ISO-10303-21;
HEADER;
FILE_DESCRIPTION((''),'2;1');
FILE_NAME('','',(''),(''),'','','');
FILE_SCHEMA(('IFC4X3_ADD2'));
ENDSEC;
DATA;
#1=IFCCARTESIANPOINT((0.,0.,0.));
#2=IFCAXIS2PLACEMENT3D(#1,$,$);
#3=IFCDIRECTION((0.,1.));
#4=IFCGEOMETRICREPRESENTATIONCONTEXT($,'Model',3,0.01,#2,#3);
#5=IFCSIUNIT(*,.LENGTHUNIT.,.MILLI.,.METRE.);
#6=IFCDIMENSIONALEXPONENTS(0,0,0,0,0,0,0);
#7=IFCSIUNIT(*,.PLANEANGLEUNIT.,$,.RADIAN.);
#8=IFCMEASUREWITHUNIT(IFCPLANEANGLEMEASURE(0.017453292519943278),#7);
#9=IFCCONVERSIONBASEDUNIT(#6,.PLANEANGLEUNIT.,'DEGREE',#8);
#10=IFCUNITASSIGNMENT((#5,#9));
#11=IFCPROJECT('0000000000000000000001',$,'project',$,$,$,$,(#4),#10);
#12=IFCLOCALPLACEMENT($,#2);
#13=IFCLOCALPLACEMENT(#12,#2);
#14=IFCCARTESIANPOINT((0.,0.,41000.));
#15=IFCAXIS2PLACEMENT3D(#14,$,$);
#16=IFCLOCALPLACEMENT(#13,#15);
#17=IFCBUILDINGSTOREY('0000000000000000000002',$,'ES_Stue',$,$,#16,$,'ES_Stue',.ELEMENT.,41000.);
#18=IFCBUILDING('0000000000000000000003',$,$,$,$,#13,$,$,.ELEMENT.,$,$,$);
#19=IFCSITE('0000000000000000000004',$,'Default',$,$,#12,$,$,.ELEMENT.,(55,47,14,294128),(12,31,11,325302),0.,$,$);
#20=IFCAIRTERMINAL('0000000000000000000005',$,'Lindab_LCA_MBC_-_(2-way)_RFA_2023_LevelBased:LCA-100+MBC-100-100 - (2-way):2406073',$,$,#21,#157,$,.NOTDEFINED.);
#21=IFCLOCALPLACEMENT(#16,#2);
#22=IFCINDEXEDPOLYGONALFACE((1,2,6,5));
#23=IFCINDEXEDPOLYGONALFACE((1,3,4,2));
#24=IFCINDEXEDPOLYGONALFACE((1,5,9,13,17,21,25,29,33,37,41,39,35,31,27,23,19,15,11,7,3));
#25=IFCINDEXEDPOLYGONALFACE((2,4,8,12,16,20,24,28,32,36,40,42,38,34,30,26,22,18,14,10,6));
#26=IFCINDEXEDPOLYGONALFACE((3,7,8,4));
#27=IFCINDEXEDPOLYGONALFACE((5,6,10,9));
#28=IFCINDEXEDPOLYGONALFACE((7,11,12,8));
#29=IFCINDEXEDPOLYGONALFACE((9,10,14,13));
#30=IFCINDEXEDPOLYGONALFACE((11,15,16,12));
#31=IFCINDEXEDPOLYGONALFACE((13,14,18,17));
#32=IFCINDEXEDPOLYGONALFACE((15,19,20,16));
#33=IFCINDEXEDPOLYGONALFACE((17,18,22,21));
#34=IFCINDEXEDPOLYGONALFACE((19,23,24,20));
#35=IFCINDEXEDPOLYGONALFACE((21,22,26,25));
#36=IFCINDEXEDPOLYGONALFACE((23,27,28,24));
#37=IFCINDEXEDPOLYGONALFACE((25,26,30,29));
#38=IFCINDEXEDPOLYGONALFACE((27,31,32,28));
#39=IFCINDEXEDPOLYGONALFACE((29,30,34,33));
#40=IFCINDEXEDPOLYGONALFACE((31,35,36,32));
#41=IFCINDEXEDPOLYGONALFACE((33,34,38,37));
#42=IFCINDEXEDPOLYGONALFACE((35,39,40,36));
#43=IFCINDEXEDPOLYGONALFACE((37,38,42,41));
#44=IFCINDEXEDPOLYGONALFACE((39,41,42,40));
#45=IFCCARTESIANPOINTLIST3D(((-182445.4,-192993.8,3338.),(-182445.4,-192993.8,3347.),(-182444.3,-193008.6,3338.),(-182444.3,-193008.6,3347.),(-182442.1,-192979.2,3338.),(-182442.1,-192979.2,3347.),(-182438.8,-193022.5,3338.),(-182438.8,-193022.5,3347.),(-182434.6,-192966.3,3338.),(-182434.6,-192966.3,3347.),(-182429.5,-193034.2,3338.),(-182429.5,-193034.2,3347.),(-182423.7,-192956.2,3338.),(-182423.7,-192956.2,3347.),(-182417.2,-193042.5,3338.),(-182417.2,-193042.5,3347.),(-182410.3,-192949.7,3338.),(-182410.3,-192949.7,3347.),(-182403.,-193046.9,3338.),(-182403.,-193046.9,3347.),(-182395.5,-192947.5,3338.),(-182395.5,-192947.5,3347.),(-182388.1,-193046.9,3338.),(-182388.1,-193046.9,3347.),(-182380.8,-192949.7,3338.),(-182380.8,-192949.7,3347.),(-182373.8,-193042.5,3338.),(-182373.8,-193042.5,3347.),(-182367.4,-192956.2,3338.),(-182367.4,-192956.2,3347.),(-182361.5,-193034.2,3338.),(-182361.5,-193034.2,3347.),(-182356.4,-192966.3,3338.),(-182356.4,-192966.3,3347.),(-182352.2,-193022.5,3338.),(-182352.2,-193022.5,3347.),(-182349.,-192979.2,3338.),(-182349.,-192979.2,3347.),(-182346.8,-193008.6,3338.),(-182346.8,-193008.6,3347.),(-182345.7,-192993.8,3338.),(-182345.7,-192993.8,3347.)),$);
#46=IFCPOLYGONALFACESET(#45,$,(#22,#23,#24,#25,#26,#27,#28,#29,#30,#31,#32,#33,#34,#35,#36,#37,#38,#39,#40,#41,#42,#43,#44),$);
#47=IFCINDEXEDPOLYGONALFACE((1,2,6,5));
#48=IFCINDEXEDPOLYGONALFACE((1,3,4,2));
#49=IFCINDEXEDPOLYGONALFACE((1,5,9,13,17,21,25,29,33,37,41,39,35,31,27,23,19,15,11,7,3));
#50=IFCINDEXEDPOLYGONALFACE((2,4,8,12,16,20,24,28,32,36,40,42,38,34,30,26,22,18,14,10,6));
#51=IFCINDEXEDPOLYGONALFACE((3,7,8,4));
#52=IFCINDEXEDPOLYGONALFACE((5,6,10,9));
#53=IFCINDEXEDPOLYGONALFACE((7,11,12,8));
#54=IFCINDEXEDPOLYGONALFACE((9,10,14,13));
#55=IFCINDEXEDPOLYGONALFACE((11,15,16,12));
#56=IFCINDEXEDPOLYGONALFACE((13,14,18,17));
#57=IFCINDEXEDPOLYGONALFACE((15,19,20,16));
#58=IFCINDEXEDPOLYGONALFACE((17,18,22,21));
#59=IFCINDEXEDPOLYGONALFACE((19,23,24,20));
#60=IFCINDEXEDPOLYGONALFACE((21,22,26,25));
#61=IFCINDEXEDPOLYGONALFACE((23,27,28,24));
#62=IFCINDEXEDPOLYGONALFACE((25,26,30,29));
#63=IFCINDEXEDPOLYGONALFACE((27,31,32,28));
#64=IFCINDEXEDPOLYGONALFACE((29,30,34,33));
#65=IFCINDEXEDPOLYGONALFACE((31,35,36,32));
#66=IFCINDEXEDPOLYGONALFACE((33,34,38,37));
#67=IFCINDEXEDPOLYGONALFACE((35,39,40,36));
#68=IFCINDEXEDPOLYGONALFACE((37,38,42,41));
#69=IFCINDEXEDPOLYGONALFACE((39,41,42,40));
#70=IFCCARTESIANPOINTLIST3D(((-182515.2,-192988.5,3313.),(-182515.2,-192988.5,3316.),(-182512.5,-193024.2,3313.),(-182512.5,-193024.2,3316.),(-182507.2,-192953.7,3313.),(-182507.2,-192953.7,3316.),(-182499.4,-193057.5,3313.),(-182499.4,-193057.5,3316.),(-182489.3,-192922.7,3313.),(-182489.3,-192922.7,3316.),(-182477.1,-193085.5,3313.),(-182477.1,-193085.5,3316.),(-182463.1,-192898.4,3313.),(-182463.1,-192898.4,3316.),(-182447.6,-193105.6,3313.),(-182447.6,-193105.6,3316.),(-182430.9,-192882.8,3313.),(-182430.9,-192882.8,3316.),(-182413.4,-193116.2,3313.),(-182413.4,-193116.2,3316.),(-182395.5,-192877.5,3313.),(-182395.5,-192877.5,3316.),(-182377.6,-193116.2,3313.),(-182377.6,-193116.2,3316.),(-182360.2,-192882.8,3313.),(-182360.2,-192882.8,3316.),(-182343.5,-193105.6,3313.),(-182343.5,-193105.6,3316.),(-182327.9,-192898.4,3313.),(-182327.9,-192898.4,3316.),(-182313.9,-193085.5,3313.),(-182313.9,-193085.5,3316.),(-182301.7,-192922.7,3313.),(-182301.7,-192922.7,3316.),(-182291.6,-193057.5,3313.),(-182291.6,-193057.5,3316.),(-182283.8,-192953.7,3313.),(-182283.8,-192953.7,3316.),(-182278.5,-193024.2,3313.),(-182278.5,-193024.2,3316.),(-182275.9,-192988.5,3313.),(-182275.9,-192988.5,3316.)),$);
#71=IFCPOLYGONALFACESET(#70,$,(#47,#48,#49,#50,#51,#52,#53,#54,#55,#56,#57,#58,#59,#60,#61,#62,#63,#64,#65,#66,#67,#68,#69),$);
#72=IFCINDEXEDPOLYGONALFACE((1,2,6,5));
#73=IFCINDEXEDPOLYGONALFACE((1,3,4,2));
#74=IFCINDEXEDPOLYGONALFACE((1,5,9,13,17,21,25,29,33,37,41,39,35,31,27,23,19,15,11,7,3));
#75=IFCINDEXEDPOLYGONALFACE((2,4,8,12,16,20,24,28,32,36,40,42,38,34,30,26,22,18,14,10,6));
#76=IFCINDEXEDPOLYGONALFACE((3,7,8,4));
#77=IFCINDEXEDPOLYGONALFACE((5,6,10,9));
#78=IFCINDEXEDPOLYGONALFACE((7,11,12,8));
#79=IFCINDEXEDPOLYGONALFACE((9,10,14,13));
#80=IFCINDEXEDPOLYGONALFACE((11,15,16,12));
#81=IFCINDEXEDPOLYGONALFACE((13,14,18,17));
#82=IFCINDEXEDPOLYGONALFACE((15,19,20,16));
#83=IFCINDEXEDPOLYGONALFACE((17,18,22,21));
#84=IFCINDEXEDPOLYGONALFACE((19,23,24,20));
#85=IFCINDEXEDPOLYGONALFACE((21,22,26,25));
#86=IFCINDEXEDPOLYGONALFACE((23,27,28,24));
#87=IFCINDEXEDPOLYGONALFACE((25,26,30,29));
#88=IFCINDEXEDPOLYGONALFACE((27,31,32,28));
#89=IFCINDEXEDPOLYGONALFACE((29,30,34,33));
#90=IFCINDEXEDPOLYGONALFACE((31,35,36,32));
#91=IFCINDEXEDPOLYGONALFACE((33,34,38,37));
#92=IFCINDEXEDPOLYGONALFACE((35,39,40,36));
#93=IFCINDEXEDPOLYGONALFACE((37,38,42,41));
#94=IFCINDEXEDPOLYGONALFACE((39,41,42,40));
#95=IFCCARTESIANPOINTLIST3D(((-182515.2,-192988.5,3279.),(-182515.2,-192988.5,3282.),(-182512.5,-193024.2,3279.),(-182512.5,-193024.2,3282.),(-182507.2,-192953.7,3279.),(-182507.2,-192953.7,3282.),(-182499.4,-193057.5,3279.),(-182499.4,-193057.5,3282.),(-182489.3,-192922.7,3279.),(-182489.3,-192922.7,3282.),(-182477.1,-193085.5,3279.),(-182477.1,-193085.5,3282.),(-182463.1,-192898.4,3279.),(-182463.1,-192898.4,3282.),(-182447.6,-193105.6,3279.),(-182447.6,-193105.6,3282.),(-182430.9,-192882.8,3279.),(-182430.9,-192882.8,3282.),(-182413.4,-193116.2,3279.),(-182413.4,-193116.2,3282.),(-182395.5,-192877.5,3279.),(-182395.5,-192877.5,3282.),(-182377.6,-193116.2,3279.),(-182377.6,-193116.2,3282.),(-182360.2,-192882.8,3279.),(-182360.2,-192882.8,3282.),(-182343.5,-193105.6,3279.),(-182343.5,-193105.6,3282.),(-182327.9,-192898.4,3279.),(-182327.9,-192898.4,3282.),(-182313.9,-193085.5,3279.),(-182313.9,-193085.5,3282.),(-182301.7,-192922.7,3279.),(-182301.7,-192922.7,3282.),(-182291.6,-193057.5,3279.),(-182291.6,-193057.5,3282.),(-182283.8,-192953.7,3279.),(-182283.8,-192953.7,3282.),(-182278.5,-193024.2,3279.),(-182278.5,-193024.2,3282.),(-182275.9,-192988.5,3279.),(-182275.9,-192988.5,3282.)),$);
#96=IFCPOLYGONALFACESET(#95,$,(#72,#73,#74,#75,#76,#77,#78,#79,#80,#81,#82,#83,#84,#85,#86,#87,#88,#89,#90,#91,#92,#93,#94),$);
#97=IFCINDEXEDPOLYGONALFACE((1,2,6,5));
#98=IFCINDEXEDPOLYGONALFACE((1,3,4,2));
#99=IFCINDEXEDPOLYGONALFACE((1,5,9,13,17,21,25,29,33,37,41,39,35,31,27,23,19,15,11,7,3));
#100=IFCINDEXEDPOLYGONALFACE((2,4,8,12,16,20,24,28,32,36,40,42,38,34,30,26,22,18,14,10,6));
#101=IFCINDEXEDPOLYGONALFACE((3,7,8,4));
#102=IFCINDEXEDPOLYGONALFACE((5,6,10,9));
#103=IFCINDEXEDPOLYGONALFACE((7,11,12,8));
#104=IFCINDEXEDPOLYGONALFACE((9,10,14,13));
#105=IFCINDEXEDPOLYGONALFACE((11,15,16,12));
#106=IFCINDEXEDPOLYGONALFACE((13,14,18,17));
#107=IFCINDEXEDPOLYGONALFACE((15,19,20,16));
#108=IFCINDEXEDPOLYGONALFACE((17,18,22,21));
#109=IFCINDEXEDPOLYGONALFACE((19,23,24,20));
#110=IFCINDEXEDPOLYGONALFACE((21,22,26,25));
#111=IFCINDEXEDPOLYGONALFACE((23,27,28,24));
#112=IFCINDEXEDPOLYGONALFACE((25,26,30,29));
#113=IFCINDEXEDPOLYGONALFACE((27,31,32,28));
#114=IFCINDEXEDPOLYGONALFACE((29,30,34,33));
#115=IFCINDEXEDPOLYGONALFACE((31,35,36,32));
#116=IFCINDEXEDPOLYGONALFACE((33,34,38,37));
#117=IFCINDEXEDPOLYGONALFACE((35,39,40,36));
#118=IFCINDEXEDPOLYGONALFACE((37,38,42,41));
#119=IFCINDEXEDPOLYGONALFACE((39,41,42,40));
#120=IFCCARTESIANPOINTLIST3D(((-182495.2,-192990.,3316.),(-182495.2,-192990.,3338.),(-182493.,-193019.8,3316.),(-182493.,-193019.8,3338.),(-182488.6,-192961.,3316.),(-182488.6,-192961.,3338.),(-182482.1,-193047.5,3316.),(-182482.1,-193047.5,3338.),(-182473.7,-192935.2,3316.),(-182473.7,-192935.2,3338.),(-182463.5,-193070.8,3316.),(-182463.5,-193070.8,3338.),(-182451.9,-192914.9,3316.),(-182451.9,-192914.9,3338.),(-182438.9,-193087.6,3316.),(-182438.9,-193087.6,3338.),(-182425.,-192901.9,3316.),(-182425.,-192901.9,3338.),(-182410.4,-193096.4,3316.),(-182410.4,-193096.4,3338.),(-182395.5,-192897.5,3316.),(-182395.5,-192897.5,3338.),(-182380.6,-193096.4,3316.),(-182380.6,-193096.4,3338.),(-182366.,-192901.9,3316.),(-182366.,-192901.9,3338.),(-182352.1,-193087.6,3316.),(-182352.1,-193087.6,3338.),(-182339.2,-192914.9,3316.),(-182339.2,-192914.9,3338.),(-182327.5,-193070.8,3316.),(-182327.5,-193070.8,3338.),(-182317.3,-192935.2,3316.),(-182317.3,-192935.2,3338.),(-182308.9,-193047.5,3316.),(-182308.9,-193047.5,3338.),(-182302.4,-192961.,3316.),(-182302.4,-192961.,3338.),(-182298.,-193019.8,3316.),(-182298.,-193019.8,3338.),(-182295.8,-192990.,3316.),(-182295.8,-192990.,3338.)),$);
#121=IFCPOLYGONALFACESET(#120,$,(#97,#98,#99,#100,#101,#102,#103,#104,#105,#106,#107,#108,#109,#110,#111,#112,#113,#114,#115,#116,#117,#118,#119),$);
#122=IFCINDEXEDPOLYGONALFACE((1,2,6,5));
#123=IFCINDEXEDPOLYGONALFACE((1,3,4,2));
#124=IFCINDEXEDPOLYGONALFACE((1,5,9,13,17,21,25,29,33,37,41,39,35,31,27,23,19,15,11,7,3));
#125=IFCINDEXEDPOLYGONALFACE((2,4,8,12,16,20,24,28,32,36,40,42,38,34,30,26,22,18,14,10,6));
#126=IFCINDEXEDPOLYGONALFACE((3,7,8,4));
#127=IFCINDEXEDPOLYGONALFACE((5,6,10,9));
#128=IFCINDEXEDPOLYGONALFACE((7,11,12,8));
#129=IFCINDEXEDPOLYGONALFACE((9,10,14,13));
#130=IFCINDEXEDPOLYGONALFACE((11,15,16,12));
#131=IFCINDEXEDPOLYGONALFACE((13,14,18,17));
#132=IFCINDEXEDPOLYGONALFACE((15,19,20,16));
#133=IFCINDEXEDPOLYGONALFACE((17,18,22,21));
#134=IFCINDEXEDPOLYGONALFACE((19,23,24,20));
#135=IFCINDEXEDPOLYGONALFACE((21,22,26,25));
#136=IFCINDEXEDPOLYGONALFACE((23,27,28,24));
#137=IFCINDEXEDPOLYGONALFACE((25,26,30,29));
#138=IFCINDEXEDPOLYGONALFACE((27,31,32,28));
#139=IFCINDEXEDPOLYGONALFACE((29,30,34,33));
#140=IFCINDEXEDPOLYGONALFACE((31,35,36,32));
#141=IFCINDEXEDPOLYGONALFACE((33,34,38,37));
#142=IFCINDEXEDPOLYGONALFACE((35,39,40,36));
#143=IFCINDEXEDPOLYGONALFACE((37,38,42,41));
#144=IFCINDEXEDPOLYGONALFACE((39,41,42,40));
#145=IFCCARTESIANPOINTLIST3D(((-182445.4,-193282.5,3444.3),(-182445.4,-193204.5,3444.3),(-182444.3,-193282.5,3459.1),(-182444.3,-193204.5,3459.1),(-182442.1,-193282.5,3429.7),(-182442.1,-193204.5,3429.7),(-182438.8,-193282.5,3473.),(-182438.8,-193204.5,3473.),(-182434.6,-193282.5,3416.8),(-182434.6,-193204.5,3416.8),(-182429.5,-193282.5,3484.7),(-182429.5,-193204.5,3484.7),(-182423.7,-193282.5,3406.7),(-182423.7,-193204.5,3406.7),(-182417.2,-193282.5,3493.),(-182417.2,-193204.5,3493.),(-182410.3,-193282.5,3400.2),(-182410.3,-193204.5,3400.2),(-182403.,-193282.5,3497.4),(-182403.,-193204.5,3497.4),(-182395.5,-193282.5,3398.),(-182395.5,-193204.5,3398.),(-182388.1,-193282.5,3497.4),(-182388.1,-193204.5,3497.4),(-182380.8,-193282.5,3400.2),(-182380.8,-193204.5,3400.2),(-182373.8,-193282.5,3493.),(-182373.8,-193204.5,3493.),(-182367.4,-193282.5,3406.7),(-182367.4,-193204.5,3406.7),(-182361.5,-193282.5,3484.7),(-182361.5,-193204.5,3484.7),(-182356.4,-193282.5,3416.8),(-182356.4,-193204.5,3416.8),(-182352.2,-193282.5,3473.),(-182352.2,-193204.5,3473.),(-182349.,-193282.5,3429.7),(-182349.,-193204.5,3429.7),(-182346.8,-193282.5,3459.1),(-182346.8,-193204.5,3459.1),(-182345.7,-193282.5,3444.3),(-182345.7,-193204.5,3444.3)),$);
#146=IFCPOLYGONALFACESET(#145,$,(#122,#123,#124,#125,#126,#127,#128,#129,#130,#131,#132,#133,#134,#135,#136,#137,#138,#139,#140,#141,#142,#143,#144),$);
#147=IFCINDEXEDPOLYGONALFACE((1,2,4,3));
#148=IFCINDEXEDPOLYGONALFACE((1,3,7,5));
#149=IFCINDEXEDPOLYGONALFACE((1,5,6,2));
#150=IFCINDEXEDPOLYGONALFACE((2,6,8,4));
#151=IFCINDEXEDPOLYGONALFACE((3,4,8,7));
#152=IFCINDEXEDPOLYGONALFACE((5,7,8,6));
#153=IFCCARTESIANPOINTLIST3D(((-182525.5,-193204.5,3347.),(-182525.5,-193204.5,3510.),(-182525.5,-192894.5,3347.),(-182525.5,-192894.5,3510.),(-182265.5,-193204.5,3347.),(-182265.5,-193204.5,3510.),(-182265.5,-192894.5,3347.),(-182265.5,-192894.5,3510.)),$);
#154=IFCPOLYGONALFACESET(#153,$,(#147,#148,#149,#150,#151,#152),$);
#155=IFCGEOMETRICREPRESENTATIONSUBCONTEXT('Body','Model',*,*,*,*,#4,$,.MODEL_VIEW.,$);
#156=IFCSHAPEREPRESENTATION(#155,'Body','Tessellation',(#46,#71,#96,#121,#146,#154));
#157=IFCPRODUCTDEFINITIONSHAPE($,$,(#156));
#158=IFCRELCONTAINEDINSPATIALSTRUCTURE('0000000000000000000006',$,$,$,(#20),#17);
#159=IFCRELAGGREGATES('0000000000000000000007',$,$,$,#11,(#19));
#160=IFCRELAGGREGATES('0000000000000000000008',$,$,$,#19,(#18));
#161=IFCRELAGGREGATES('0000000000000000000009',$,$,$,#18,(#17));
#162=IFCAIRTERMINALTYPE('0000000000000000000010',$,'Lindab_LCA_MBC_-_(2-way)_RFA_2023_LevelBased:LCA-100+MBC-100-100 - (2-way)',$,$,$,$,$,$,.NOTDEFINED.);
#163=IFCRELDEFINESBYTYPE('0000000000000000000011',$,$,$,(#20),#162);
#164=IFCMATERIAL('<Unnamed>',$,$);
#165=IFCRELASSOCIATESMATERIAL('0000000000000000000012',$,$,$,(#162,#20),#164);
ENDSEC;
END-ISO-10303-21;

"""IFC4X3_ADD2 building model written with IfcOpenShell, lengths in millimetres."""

from ifc_helpers import new_model, entity, si_unit, converted_unit, direction, frame, frame_2d, origin, origin_2d_with_axis, place, context, subcontext, project, spatial, rectangle, circle, extrude, source, transform, mapped, material, type_object, type_shapes, element, save


model = new_model("IFC4X3_ADD2")

# Units and contexts
model_context = context("Model", 3, precision=0.01, world=origin(), true_north=direction((0.0, 1.0)))
body_context = subcontext(model_context, "Body", "Model", "MODEL_VIEW")
ifc_project = project(units=[si_unit("LENGTHUNIT", "METRE", prefix="MILLI"), converted_unit("PLANEANGLEUNIT", "DEGREE", entity("IfcPlaneAngleMeasure", 0.017453292519943278), si_unit("PLANEANGLEUNIT", "RADIAN"), dimensions=[0, 0, 0, 0, 0, 0, 0])], contexts=[model_context])

# Site, building, storey
site_placement = place(None, origin())
site = spatial("IfcSite", under=ifc_project, at=site_placement, Name="Default", CompositionType="ELEMENT", RefLatitude=(55, 47, 14, 294128), RefLongitude=(12, 31, 11, 325302), RefElevation=0.0)
building_placement = place(site_placement, origin())
building = spatial("IfcBuilding", under=site, at=building_placement, CompositionType="ELEMENT")
storey_placement = place(building_placement, frame((0.0, 0.0, 41000.0)))
storey = spatial("IfcBuildingStorey", under=building, at=storey_placement, Name="ES_Stue", LongName="ES_Stue", CompositionType="ELEMENT", Elevation=41000.0)

# Air terminal
ifc_material_1 = material(Name="<Unnamed>")
air_terminal_type = type_object("IfcAirTerminalType", Name="Lindab_LCA_MBC_-_(2-way)_RFA_2023_LevelBased:LCA-100+MBC-100-100 - (2-way)", PredefinedType="NOTDEFINED", material=ifc_material_1)
shared_shape_1 = source(origin(), body_context, "Body", "SweptSolid", [
    extrude(circle(Radius=50.0, at=frame_2d((0.0, 0.0), x_axis=(1.0, 0.0))), frame((0.0, 0.0, 22.0)), (0.0, 0.0, 1.0), 9.0),
    extrude(circle(Radius=120.0, at=frame_2d((0.0, 0.0), x_axis=(1.0, 0.0))), frame((0.0, 0.0, -3.0)), (0.0, 0.0, 1.0), 3.0),
    extrude(circle(Radius=120.0, at=frame_2d((0.0, 0.0), x_axis=(1.0, 0.0))), frame((0.0, 0.0, -37.0)), (0.0, 0.0, 1.0), 3.0),
    extrude(circle(Radius=100.0, at=frame_2d((0.0, 0.0), x_axis=(1.0, 0.0))), origin(), (0.0, 0.0, 1.0), 22.0),
    extrude(circle(Radius=50.0, at=frame_2d((0.0, 0.0), x_axis=(1.0, 0.0))), frame((-285.0, 0.0, 132.0), z_axis=(1.0, 0.0, 0.0), x_axis=(0.0, 0.0, -1.0)), (0.0, 0.0, 1.0), 78.0),
    extrude(rectangle(XDim=260.0, YDim=310.0, at=origin_2d_with_axis()), frame((-52.0, 0.0, 31.0), z_axis=(0.0, 0.0, 1.0), x_axis=(0.0, -1.0, 0.0)), (0.0, 0.0, 1.0), 163.0),
])
type_shapes(air_terminal_type, [shared_shape_1])
for number, where, z_axis, x_axis, name in (
    (1, (-182395.5, -192997.5, 3316.0), (0.0, 0.0, 1.0), (0.0, 1.0, 0.0), "Lindab_LCA_MBC_-_(2-way)_RFA_2023_LevelBased:LCA-100+MBC-100-100 - (2-way):2406073"),
):
    element("IfcAirTerminal", number, at=place(storey_placement, frame(where, z_axis=z_axis, x_axis=x_axis)), inside=storey, type_object=air_terminal_type, material=ifc_material_1, Name=name, PredefinedType="NOTDEFINED", context=body_context, shape_type="MappedRepresentation", body=[
        mapped(shared_shape_1, transform((0.0, 0.0, 0.0), scale=1.0)),
    ])

save(model, "model.ifc")
